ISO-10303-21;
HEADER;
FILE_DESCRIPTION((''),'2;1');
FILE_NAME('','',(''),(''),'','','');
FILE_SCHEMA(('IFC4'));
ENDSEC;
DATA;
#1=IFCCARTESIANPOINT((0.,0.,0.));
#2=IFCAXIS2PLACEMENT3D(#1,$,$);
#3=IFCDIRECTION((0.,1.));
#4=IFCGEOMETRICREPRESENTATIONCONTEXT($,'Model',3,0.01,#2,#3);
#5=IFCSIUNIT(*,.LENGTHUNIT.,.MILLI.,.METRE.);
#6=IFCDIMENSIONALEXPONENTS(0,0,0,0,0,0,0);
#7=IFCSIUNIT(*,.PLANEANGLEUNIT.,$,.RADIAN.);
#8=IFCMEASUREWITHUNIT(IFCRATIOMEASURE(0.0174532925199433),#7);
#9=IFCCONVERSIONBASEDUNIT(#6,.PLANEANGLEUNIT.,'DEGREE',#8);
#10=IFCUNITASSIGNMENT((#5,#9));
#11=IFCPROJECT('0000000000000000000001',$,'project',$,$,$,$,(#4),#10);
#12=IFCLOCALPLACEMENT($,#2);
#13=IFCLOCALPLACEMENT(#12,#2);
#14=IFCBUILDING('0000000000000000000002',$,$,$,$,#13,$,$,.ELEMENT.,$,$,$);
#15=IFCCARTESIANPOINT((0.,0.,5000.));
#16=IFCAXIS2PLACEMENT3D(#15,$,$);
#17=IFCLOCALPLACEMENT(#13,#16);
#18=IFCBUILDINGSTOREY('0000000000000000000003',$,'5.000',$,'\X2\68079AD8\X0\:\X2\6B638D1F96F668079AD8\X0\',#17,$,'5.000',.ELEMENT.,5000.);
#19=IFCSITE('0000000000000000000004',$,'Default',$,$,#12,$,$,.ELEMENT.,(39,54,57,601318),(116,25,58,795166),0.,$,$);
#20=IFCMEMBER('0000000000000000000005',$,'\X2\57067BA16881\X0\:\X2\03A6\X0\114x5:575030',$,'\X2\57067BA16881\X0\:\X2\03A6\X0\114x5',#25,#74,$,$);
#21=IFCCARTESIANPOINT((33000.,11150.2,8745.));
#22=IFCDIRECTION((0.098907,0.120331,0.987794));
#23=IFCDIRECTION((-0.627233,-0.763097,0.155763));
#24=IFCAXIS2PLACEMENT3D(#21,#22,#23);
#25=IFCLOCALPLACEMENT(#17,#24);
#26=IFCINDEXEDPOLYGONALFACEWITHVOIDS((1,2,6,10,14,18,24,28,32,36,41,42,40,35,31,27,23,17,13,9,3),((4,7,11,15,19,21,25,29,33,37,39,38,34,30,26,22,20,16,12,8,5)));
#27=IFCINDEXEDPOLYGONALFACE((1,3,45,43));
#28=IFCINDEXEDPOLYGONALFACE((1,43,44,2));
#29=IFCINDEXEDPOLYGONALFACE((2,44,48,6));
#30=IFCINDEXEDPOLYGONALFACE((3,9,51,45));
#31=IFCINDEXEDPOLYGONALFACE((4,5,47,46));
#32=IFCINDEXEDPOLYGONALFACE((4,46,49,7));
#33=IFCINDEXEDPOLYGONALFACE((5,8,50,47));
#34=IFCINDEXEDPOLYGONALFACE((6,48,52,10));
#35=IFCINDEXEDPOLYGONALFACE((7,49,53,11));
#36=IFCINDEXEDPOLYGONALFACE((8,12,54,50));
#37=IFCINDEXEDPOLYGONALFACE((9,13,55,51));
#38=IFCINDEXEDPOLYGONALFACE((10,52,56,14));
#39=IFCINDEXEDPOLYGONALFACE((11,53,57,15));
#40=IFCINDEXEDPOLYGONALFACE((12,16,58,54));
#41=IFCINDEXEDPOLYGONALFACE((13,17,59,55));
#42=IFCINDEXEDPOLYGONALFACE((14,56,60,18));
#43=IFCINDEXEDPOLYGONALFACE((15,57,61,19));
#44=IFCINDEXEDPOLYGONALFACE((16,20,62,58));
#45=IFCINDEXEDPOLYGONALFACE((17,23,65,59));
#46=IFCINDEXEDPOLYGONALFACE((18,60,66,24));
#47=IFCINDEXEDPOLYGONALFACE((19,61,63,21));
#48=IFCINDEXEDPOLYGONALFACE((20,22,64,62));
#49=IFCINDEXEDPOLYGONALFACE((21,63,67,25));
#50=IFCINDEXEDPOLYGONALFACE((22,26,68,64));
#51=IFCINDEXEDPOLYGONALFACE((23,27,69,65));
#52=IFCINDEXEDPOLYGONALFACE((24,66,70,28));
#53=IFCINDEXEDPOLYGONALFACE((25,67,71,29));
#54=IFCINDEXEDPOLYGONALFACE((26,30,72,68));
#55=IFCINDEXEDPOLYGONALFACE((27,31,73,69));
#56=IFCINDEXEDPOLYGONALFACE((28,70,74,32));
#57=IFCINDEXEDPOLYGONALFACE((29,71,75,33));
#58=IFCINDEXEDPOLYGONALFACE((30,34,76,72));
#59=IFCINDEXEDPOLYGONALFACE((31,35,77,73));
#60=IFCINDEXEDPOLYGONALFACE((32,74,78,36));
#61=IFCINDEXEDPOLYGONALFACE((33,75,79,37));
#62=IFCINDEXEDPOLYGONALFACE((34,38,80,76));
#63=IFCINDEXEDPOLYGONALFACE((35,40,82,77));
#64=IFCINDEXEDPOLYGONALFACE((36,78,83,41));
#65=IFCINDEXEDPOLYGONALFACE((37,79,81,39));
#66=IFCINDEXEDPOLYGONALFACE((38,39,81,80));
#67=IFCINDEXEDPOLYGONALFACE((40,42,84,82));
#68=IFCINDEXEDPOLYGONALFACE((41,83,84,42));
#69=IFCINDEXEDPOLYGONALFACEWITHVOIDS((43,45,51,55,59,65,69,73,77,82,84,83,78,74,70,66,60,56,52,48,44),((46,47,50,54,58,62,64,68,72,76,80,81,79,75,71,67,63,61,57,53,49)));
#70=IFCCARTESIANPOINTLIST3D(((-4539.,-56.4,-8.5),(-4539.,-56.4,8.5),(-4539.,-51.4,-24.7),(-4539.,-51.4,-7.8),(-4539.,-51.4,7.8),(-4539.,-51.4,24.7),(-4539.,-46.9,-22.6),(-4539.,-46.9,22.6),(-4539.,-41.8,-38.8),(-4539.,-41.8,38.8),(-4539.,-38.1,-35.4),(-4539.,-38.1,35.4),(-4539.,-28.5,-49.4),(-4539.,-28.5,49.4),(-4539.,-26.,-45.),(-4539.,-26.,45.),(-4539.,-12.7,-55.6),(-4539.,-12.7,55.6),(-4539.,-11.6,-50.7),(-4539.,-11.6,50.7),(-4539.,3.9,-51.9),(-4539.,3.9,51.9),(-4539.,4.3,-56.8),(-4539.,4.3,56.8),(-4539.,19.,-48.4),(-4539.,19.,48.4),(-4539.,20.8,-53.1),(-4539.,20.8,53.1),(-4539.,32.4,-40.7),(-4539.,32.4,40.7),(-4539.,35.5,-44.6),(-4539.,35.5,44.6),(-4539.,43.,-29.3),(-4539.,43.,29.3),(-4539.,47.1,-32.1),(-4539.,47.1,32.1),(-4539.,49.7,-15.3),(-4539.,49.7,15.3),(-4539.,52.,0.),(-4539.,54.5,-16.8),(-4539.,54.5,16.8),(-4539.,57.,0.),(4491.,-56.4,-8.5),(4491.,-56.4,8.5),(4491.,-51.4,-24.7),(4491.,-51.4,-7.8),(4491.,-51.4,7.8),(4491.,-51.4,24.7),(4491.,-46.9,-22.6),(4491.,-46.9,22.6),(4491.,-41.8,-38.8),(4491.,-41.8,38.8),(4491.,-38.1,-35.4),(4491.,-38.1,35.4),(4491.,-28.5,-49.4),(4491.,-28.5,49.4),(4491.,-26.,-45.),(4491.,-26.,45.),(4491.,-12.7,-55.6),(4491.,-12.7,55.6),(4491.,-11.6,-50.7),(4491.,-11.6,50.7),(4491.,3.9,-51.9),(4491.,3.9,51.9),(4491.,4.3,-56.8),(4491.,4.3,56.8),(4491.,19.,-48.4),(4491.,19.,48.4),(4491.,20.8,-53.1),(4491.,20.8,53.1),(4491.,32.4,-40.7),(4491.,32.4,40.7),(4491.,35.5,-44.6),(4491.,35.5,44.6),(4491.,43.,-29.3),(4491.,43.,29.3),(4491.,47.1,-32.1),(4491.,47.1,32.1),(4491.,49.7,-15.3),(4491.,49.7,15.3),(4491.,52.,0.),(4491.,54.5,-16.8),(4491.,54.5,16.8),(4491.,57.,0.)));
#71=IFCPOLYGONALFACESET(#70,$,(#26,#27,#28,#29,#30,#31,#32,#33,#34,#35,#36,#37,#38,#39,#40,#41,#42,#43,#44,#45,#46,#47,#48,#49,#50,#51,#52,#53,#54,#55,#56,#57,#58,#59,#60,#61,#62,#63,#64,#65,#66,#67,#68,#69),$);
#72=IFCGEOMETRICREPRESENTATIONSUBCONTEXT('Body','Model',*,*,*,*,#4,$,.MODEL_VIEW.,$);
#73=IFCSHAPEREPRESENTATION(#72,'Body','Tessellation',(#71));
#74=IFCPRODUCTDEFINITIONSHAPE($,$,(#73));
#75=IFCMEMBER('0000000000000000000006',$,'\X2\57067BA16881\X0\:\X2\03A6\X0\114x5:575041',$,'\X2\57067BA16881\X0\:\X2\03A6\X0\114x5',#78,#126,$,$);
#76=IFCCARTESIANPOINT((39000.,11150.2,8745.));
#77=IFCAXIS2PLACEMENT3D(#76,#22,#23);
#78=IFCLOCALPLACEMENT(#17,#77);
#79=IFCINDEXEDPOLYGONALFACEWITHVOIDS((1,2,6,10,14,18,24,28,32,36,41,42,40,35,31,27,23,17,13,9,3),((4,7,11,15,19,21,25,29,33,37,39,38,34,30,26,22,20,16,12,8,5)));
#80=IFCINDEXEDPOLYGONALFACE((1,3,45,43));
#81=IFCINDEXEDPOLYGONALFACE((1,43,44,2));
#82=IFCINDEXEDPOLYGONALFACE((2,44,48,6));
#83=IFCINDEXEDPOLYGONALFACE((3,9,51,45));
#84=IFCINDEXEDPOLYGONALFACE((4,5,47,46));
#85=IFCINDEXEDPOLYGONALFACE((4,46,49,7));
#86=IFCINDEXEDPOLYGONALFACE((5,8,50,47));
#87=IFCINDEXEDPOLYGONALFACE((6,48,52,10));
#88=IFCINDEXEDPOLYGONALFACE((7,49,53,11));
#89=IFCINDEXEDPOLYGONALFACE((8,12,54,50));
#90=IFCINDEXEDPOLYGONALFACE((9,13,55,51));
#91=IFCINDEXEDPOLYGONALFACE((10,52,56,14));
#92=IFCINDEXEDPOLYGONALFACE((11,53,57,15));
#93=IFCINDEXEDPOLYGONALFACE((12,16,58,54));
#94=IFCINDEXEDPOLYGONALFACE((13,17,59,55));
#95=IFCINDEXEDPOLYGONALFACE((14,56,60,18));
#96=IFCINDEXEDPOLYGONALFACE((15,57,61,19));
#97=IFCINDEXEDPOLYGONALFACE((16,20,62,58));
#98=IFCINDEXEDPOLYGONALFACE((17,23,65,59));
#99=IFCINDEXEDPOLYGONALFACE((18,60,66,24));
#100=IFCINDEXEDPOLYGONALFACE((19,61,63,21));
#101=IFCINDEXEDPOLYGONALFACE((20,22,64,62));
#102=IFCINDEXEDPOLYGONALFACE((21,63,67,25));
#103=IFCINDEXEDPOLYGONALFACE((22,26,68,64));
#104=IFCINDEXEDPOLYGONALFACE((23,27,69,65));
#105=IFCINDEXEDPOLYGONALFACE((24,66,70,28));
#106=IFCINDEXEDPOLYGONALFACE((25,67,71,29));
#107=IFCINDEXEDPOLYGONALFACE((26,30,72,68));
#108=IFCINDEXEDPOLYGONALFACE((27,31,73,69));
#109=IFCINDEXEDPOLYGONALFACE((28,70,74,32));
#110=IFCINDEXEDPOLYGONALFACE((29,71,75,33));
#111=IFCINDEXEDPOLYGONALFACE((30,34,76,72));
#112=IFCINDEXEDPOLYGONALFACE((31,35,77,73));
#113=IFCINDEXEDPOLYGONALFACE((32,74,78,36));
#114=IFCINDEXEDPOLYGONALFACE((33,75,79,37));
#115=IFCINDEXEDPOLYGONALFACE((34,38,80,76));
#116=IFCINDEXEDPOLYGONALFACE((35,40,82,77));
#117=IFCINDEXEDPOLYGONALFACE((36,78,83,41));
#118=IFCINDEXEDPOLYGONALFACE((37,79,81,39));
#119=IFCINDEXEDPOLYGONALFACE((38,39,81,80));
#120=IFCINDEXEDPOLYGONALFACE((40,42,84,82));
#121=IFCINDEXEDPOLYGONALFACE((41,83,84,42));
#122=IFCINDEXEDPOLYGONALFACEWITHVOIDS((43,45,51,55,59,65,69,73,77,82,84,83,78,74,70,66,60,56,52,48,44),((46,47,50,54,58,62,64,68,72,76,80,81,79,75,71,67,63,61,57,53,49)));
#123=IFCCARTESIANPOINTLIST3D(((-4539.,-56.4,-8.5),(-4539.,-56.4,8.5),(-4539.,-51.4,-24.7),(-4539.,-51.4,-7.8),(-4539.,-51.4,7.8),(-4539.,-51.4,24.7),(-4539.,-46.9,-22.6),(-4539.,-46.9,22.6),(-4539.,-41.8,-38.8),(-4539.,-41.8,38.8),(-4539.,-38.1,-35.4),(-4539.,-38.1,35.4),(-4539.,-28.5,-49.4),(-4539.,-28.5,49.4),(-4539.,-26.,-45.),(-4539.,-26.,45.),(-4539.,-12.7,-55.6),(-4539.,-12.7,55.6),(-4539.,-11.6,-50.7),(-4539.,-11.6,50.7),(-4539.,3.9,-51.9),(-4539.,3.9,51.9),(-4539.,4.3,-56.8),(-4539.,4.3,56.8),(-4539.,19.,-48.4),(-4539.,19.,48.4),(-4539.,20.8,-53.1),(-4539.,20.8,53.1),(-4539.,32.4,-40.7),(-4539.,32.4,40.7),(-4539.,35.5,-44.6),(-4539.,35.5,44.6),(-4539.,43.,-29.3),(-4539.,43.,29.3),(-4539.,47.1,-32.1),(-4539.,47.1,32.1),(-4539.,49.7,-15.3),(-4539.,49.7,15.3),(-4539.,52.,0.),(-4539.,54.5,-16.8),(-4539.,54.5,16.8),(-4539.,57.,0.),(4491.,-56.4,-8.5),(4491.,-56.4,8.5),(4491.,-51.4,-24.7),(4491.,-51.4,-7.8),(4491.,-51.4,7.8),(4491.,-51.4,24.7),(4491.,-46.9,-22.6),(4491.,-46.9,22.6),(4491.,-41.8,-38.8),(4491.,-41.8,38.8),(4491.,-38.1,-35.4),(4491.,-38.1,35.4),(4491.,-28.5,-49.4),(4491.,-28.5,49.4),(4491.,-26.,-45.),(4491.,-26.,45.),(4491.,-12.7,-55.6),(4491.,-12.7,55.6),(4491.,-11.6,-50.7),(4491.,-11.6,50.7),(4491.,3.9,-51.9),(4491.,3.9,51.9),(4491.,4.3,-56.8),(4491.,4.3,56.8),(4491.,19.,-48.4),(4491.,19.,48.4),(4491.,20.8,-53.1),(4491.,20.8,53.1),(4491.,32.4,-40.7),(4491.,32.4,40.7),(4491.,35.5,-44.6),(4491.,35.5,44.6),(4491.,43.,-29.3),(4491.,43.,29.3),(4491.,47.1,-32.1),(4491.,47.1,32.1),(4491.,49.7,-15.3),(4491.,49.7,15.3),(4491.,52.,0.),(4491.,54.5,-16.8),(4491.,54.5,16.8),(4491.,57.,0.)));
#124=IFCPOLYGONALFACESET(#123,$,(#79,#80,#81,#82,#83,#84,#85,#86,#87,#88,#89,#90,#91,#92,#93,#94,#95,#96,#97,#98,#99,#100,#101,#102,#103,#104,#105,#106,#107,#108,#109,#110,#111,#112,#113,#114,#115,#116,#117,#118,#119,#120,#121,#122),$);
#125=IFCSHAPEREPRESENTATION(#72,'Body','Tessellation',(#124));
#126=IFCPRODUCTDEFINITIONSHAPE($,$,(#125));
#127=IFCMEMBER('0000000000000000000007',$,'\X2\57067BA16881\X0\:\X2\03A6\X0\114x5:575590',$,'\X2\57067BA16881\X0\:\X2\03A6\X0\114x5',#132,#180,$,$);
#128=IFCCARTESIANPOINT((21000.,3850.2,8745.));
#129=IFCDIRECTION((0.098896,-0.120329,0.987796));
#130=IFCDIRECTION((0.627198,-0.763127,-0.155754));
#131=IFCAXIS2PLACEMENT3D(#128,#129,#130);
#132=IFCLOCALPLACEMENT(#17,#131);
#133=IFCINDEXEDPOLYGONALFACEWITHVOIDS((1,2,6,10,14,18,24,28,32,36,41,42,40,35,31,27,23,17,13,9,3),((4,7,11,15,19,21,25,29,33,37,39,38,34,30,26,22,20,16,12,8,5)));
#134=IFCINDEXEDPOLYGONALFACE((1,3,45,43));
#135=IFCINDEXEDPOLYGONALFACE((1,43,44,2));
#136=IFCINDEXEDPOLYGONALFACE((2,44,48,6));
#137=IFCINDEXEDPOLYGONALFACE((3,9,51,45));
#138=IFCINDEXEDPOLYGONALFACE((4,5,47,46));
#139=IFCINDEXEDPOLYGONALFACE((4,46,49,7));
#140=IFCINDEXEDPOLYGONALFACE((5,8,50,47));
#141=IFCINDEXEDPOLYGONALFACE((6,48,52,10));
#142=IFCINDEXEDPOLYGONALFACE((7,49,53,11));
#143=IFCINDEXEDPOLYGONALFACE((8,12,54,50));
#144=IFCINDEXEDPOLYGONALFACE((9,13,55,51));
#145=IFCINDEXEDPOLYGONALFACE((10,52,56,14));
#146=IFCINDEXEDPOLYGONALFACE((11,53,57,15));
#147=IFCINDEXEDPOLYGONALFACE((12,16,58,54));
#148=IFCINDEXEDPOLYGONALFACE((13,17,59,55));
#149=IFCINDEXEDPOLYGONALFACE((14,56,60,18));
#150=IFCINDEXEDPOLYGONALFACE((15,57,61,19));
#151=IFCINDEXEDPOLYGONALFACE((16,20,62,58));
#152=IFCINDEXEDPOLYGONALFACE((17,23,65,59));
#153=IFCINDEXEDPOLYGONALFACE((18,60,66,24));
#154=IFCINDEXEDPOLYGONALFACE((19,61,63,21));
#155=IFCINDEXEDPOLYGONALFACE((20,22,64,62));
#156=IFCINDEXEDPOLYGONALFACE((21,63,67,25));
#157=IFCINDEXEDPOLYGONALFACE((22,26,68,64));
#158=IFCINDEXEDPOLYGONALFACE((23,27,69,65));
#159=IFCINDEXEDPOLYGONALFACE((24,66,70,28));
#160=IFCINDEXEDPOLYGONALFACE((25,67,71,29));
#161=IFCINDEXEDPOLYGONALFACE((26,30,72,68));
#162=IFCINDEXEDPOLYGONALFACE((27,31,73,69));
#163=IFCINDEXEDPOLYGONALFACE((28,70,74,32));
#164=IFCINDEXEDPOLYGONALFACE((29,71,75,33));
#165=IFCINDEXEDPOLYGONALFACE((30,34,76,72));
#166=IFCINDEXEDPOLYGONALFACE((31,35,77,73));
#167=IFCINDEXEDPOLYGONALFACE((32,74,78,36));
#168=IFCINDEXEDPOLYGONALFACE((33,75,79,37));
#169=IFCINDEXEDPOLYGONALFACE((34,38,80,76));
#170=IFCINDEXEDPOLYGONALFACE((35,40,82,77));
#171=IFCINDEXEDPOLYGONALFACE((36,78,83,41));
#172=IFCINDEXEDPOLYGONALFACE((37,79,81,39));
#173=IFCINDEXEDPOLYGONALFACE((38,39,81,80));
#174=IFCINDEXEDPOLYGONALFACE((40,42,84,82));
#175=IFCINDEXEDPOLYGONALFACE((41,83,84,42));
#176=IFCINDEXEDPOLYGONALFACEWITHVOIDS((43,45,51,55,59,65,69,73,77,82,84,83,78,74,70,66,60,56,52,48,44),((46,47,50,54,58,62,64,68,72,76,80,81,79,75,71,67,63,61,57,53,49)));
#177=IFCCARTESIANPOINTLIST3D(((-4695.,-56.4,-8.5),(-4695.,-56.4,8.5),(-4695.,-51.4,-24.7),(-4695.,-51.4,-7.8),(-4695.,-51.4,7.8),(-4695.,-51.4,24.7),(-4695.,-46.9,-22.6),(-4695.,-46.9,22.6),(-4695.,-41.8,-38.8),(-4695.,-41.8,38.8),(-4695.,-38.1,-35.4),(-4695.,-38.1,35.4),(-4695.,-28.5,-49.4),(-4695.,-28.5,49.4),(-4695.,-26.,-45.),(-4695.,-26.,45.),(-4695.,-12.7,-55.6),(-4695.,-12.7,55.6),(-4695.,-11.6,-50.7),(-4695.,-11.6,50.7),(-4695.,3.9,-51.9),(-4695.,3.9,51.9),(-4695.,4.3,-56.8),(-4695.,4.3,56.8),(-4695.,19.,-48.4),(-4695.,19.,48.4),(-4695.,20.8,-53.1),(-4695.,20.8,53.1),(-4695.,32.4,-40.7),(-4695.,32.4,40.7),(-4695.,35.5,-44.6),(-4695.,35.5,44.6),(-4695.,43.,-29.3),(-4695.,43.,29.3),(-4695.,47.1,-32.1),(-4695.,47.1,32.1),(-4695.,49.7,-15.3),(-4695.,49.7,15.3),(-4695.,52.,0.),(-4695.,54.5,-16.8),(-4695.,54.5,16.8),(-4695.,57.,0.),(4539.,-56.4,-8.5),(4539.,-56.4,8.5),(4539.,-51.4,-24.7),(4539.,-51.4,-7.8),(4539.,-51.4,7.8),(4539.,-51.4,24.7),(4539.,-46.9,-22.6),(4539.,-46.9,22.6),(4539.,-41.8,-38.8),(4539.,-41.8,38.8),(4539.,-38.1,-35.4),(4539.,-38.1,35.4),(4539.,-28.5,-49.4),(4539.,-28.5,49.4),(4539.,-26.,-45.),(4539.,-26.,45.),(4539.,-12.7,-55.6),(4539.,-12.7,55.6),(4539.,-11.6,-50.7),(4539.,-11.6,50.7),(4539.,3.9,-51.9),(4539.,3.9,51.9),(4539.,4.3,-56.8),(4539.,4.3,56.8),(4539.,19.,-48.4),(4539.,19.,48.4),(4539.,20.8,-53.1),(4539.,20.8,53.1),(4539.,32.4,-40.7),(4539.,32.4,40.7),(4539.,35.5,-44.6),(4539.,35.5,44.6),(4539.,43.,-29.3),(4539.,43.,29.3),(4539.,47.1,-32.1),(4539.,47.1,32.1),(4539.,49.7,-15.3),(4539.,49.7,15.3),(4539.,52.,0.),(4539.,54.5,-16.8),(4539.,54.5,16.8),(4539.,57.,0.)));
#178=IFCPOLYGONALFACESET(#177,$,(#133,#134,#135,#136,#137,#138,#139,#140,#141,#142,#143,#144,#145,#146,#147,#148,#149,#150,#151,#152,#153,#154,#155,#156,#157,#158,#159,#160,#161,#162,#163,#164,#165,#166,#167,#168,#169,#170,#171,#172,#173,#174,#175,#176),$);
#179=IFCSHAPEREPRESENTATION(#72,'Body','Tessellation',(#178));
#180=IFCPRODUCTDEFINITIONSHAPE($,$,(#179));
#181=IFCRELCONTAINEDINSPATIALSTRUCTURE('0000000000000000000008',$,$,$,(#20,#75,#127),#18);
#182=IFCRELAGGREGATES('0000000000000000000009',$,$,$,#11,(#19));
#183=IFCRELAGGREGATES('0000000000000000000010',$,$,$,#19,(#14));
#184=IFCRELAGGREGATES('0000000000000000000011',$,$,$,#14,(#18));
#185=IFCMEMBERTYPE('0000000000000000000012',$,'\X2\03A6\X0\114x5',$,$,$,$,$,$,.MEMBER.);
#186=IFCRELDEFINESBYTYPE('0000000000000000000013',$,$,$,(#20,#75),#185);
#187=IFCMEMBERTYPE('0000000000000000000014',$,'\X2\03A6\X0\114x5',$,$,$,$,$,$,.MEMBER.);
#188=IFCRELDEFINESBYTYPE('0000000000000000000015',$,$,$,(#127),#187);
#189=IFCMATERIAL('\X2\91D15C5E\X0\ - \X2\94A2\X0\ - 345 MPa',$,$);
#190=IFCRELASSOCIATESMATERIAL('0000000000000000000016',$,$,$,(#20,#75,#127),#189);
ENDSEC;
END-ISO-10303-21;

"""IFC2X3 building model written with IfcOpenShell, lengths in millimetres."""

from ifc_helpers import new_model, entity, si_unit, converted_unit, direction, frame, frame_2d, origin, place, context, subcontext, project, spatial, hollow_circle, extrude, source, transform, mapped, material, type_object, type_shapes, element, save


model = new_model("IFC2X3")

# Units and contexts
model_context = context("Model", 3, precision=0.01, world=origin(), true_north=direction((0.0, 1.0)))
body_context = subcontext(model_context, "Body", "Model", "MODEL_VIEW")
ifc_project = project(units=[si_unit("LENGTHUNIT", "METRE", prefix="MILLI"), converted_unit("PLANEANGLEUNIT", "DEGREE", entity("IfcRatioMeasure", 0.0174532925199433), si_unit("PLANEANGLEUNIT", "RADIAN"), dimensions=[0, 0, 0, 0, 0, 0, 0])], contexts=[model_context])

# Site, building, storey
site_placement = place(None, origin())
site = spatial("IfcSite", under=ifc_project, at=site_placement, Name="Default", CompositionType="ELEMENT", RefLatitude=(39, 54, 57, 601318), RefLongitude=(116, 25, 58, 795166), RefElevation=0.0)
building_placement = place(site_placement, origin())
building = spatial("IfcBuilding", under=site, at=building_placement, CompositionType="ELEMENT")
storey_placement = place(building_placement, frame((0.0, 0.0, 5000.0)))
storey = spatial("IfcBuildingStorey", under=building, at=storey_placement, Name="5.000", ObjectType="标高:正负零标高", LongName="5.000", CompositionType="ELEMENT", Elevation=5000.0)

# Members
ifc_material_1 = material(Name="金属 - 钢 - 345 MPa")
member_type_1 = type_object("IfcMemberType", Name="Φ114x5", PredefinedType="MEMBER")
shared_shape_1 = source(origin(), body_context, "Body", "SweptSolid", [
    extrude(hollow_circle(Radius=57.0, WallThickness=5.0, at=frame_2d((0.0, 0.0), x_axis=(1.0, 0.0))), frame((-4539.0, 0.0, 0.0), z_axis=(1.0, 0.0, 0.0), x_axis=(0.0, 1.0, 0.0)), (0.0, 0.0, 1.0), 9030.0),
])
type_shapes(member_type_1, [shared_shape_1])
for number, where, z_axis, x_axis, name in (
    (1, (33000.0, 11150.2, 8745.0), (0.098907, 0.120331, 0.987794), (-0.627233, -0.763097, 0.155763), "圆管梁:Φ114x5:575030"),
    (2, (39000.0, 11150.2, 8745.0), (0.098907, 0.120331, 0.987794), (-0.627233, -0.763097, 0.155763), "圆管梁:Φ114x5:575041"),
):
    element("IfcMember", number, at=place(storey_placement, frame(where, z_axis=z_axis, x_axis=x_axis)), inside=storey, type_object=member_type_1, material=ifc_material_1, Name=name, ObjectType="圆管梁:Φ114x5", context=body_context, shape_type="MappedRepresentation", body=[
        mapped(shared_shape_1, transform((0.0, 0.0, 0.0), scale=1.0)),
    ])
member_type_2 = type_object("IfcMemberType", Name="Φ114x5", PredefinedType="MEMBER")
shared_shape_2 = source(origin(), body_context, "Body", "SweptSolid", [
    extrude(hollow_circle(Radius=57.0, WallThickness=5.0, at=frame_2d((0.0, 0.0), x_axis=(1.0, 0.0))), frame((-4695.0, 0.0, 0.0), z_axis=(1.0, 0.0, 0.0), x_axis=(0.0, 1.0, 0.0)), (0.0, 0.0, 1.0), 9234.0),
])
type_shapes(member_type_2, [shared_shape_2])
for number, where, z_axis, x_axis, name in (
    (3, (21000.0, 3850.2, 8745.0), (0.098896, -0.120329, 0.987796), (0.627198, -0.763127, -0.155754), "圆管梁:Φ114x5:575590"),
):
    element("IfcMember", number, at=place(storey_placement, frame(where, z_axis=z_axis, x_axis=x_axis)), inside=storey, type_object=member_type_2, material=ifc_material_1, Name=name, ObjectType="圆管梁:Φ114x5", context=body_context, shape_type="MappedRepresentation", body=[
        mapped(shared_shape_2, transform((0.0, 0.0, 0.0), scale=1.0)),
    ])

save(model, "model.ifc")
